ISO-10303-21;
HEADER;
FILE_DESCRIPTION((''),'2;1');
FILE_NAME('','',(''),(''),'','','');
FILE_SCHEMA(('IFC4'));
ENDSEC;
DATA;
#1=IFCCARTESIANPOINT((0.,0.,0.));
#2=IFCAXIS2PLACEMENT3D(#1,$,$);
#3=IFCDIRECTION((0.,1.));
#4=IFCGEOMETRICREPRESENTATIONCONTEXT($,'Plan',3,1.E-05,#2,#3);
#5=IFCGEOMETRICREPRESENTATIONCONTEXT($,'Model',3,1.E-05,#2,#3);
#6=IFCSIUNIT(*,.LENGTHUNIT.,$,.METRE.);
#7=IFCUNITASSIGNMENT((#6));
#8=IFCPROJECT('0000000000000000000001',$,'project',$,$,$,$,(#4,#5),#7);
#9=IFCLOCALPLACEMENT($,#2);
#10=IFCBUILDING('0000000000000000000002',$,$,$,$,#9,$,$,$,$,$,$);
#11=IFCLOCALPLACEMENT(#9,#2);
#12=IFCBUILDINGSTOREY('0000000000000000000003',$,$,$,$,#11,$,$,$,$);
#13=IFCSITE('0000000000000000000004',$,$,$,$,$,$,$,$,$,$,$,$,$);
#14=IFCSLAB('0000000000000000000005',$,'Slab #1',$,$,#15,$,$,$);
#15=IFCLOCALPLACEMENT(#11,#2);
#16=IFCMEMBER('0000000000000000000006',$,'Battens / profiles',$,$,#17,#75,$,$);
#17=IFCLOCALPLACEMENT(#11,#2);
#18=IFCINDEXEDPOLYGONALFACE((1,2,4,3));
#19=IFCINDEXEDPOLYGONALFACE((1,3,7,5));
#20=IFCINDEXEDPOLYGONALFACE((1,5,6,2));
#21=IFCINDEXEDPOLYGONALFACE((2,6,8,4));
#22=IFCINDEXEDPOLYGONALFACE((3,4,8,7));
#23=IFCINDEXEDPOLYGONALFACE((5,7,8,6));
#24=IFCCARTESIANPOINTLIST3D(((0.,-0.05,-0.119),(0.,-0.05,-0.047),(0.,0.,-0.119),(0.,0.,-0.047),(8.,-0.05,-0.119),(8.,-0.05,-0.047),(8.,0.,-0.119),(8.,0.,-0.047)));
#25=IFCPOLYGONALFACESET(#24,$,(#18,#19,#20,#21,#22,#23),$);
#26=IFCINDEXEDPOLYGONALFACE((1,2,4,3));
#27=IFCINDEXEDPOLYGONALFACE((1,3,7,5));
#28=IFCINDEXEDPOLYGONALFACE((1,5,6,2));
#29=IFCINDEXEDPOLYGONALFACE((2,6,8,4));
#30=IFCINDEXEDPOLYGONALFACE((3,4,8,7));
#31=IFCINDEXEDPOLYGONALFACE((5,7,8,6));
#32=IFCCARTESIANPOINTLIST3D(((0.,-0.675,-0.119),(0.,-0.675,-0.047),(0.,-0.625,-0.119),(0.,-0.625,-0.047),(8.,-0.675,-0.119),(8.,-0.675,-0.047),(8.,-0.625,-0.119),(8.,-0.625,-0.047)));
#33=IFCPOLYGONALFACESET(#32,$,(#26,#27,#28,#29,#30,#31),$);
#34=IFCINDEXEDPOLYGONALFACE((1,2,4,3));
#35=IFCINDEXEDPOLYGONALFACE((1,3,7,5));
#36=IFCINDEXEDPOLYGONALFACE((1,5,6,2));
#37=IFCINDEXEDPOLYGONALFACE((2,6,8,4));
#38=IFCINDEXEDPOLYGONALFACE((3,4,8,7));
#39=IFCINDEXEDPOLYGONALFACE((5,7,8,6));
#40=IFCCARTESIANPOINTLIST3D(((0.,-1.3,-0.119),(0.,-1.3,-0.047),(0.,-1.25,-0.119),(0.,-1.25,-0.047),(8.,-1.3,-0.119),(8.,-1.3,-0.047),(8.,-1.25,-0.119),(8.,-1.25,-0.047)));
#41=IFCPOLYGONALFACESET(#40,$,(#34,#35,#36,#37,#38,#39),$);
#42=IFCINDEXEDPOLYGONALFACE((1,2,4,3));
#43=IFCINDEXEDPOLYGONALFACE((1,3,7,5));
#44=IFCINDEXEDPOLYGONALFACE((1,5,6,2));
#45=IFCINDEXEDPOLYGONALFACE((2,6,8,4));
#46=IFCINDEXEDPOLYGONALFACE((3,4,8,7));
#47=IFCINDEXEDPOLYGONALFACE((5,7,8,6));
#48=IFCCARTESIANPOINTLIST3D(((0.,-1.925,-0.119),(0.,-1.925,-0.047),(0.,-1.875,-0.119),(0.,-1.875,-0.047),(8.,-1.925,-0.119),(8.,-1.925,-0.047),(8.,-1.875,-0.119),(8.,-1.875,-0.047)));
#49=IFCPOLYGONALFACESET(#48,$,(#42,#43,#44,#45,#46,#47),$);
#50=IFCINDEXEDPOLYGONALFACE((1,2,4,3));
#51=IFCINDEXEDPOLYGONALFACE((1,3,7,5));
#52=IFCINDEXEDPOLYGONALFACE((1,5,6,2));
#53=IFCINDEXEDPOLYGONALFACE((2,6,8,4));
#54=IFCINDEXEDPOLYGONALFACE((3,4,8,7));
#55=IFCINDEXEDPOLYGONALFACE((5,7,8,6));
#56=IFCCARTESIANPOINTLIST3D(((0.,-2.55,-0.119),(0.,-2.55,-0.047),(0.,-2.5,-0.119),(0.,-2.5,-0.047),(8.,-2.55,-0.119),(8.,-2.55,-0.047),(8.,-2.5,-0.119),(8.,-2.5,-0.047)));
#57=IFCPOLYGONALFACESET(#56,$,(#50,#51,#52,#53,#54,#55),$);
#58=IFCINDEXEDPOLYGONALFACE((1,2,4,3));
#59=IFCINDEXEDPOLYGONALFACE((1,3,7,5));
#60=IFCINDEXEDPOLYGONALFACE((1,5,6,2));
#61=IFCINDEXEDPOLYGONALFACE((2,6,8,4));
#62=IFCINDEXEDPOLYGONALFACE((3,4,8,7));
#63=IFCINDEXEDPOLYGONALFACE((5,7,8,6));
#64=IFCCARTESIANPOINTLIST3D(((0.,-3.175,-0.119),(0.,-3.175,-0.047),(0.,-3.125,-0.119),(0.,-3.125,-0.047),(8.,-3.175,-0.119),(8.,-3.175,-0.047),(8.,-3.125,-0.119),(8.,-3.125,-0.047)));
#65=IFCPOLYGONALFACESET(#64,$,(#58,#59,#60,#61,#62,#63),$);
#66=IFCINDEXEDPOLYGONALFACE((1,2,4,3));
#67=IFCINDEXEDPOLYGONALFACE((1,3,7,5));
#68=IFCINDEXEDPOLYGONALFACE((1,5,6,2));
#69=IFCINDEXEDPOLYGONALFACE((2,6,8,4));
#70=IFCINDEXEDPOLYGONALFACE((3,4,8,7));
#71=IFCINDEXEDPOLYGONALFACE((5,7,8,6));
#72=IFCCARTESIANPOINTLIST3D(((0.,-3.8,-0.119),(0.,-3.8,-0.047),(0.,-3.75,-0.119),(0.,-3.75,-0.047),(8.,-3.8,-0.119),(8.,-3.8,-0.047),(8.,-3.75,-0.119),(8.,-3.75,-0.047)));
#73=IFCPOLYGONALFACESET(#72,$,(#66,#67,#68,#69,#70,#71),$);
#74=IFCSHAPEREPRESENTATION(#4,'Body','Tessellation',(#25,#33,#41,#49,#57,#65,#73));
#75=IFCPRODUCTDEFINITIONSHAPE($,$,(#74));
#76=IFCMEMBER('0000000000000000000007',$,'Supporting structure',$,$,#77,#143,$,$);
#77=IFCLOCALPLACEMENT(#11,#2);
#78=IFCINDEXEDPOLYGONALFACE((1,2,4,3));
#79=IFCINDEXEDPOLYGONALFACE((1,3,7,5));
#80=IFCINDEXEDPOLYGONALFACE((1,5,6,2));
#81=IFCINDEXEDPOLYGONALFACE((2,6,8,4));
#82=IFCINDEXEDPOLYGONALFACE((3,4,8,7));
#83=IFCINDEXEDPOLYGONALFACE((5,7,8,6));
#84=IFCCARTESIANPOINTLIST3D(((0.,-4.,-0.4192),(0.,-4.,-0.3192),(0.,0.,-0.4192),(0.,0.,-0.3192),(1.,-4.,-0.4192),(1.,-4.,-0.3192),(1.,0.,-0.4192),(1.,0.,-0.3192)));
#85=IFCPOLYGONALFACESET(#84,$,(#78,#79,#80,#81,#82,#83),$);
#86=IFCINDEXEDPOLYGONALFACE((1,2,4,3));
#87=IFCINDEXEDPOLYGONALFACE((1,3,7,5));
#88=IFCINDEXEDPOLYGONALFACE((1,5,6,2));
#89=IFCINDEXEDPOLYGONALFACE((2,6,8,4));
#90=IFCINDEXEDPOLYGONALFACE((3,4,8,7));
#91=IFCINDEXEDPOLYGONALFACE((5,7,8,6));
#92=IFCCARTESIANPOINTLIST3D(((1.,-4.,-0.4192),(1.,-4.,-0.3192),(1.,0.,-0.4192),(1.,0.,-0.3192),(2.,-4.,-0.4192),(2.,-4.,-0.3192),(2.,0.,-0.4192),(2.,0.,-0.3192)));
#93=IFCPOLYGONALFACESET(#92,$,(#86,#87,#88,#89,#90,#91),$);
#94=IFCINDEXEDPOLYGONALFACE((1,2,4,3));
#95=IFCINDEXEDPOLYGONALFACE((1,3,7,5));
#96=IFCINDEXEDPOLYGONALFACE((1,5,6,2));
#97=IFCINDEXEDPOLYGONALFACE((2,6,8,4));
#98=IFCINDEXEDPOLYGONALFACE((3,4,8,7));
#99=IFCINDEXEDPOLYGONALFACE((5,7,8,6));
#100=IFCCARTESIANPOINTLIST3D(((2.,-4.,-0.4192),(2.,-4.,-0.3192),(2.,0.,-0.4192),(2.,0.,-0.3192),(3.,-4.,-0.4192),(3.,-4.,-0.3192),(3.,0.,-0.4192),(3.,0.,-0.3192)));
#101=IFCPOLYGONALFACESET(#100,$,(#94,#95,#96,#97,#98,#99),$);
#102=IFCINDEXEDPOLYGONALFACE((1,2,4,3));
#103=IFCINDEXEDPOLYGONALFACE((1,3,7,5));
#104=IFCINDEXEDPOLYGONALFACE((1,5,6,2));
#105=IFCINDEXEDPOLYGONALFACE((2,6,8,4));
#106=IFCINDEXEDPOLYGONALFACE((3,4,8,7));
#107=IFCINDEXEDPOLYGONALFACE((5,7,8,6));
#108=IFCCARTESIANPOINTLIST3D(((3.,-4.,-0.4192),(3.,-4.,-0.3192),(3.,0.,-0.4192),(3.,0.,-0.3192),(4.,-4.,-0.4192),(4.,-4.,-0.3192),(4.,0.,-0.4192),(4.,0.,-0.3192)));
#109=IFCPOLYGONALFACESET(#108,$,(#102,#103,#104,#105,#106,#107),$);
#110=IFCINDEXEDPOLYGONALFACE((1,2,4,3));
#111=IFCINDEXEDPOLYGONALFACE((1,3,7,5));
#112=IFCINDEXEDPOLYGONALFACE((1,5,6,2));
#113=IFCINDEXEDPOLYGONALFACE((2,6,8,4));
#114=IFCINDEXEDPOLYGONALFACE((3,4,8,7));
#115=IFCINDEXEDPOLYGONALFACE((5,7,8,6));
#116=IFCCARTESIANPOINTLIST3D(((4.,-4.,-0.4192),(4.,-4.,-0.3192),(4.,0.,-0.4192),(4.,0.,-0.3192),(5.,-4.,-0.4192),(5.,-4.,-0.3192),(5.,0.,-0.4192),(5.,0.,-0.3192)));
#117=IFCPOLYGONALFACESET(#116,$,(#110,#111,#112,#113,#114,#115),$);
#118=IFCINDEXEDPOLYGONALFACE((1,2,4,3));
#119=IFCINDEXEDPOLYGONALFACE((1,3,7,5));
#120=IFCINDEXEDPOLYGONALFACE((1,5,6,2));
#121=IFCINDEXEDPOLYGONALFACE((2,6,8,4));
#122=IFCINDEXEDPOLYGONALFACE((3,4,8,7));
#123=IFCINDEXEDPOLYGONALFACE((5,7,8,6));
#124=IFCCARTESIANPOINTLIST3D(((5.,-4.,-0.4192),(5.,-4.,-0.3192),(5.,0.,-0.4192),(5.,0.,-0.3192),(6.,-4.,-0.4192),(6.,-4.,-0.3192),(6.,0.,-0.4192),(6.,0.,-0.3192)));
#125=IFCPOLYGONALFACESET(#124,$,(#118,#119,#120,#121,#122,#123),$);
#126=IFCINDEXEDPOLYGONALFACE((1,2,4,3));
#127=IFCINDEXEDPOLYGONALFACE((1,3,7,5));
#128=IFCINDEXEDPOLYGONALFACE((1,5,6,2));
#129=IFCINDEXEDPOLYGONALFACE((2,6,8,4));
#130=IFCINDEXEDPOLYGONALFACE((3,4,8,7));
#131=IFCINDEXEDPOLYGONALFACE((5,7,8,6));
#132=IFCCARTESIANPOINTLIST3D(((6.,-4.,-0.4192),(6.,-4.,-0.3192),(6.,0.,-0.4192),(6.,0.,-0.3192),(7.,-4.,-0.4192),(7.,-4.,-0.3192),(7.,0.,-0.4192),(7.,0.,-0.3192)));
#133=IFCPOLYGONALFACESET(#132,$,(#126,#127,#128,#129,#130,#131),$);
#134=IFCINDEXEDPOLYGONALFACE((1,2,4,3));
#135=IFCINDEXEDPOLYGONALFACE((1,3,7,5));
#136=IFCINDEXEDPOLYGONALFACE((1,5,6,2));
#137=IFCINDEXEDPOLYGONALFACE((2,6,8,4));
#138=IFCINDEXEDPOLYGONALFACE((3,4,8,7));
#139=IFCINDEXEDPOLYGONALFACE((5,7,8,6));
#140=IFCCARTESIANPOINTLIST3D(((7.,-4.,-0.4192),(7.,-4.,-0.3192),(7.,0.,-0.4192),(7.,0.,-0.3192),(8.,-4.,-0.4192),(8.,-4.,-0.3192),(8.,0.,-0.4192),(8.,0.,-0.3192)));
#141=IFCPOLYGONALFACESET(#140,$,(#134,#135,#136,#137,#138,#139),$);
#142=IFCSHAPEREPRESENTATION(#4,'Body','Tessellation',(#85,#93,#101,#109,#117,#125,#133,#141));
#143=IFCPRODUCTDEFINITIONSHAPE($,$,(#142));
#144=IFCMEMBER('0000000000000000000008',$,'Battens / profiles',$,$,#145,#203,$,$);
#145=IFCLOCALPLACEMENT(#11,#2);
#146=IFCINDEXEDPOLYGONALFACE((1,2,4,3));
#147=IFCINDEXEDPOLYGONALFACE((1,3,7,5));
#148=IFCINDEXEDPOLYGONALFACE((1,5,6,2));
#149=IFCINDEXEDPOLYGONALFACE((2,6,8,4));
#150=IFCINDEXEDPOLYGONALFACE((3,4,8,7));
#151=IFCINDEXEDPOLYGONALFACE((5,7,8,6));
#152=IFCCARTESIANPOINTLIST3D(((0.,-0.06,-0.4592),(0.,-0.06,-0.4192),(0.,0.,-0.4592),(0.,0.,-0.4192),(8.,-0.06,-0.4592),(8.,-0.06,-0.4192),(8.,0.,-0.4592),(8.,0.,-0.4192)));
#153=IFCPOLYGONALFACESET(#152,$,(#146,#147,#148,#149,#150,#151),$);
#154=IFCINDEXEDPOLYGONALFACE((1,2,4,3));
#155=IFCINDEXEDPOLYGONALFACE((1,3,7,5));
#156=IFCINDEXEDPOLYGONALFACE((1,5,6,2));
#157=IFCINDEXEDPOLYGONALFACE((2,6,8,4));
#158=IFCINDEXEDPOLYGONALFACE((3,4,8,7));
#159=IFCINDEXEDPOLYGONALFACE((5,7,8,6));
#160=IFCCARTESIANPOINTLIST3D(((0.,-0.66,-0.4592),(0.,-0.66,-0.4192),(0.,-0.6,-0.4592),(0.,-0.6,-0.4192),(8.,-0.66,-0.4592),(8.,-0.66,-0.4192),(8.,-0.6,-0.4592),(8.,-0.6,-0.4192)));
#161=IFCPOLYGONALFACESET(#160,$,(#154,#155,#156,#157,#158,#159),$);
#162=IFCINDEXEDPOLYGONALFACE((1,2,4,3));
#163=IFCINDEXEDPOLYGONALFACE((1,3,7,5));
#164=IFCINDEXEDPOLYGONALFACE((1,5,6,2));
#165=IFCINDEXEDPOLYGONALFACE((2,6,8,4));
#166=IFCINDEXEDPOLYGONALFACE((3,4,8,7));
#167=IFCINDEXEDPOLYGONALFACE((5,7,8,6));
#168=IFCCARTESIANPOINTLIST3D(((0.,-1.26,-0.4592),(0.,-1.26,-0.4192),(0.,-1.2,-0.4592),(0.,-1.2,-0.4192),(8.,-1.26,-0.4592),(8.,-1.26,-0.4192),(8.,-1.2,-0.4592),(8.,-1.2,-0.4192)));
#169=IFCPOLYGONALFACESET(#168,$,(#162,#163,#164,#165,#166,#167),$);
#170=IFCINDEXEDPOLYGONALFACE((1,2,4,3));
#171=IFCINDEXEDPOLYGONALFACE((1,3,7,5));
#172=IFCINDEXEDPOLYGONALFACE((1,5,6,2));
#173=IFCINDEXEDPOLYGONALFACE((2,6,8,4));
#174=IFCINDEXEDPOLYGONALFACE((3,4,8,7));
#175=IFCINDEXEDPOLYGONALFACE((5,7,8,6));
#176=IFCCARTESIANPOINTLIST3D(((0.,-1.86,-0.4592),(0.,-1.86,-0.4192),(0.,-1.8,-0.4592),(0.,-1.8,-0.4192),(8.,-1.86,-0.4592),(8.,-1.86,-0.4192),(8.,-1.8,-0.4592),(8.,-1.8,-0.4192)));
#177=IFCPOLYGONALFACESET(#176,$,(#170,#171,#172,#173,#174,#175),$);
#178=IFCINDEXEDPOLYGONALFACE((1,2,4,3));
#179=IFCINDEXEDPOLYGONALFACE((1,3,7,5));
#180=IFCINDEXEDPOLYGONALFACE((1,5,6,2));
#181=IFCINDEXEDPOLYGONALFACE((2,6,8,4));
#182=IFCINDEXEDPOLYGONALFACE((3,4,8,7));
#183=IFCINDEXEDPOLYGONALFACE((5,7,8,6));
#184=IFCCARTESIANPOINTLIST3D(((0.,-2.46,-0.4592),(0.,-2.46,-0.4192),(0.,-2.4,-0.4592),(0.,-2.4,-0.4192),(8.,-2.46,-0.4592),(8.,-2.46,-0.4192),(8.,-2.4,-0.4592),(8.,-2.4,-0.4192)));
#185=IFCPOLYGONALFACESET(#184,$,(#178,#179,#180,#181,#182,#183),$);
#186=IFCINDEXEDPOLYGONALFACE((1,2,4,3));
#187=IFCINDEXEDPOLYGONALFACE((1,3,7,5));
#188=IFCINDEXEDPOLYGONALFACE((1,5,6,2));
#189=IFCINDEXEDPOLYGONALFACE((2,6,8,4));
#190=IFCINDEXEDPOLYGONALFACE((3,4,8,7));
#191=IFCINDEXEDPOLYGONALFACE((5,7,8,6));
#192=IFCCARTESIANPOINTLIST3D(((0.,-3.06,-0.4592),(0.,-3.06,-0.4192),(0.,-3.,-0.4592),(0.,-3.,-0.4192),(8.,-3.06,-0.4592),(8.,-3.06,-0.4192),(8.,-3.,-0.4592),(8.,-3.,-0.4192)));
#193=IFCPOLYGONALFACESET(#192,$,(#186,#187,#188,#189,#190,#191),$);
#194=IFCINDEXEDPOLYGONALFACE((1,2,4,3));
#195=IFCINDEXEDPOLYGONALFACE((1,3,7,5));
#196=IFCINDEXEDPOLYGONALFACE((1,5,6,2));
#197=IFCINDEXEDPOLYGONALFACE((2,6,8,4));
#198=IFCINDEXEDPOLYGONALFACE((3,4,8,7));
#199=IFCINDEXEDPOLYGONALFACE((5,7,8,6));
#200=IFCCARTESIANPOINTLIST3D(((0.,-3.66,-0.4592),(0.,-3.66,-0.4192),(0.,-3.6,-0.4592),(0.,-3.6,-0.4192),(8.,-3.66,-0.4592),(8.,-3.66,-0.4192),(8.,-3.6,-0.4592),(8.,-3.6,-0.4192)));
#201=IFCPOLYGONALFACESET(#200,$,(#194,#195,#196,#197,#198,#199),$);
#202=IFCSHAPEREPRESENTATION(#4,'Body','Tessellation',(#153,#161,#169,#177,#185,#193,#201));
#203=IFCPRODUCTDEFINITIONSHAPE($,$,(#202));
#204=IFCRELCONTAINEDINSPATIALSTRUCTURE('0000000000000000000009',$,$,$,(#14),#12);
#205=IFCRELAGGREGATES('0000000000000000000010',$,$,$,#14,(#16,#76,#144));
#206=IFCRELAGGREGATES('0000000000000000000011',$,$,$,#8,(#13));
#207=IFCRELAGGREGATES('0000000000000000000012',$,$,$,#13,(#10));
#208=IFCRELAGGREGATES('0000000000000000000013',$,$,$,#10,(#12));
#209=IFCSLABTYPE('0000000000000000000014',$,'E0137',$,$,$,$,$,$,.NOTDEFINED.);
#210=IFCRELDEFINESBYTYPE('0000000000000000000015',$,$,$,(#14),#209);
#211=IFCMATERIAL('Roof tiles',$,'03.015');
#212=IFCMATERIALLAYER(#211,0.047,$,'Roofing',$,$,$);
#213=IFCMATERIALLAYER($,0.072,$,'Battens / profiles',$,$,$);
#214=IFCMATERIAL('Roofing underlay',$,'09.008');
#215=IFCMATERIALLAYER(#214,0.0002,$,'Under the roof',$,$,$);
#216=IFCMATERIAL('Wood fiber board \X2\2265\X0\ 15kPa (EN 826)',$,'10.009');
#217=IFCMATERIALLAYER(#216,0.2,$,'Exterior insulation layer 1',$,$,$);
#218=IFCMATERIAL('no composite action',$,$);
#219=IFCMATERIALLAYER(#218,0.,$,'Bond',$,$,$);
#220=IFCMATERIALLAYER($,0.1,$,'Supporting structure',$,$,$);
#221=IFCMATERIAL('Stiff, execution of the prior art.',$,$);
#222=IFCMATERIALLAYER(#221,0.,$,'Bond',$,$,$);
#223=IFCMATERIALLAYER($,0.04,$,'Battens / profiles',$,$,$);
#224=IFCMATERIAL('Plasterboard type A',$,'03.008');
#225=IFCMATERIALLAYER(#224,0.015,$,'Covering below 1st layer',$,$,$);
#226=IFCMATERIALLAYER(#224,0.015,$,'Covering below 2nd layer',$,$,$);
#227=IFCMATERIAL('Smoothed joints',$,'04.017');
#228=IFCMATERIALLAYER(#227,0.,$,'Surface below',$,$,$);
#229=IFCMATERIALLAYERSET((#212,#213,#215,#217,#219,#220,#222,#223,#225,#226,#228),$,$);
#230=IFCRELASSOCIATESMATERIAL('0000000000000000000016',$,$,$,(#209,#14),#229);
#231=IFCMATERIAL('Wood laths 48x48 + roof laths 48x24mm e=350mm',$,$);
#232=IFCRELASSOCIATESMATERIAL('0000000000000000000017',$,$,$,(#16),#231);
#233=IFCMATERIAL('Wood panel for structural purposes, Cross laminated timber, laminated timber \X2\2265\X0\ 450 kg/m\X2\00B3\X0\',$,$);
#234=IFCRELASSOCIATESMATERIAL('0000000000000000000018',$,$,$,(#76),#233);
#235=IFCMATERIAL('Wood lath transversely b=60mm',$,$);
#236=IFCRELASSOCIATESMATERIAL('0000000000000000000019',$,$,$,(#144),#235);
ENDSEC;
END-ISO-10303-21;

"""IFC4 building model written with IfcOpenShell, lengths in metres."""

from ifc_helpers import new_model, si_unit, direction, frame, frame_2d, origin, place, context, project, spatial, rectangle, extrude, material, layer, layer_set, type_object, element, aggregate, save


model = new_model("IFC4")

# Units and contexts
plan_context = context("Plan", 3, precision=1e-05, world=origin(), true_north=direction((0.0, 1.0)))
model_context = context("Model", 3, precision=1e-05, world=origin(), true_north=direction((0.0, 1.0)))
ifc_project = project(units=[si_unit("LENGTHUNIT", "METRE")], contexts=[plan_context, model_context])

# Site, building, storey
site = spatial("IfcSite", under=ifc_project)
building_placement = place(None, origin())
building = spatial("IfcBuilding", under=site, at=building_placement)
storey_placement = place(building_placement, origin())
storey = spatial("IfcBuildingStorey", under=building, at=storey_placement)

# Slab, members
ifc_material_1 = material(Name="Roof tiles", Category="03.015")
ifc_layer_1 = layer(ifc_material_1, 0.047, Name="Roofing")
ifc_layer_2 = layer(None, 0.072, Name="Battens / profiles")
ifc_material_2 = material(Name="Roofing underlay", Category="09.008")
ifc_layer_3 = layer(ifc_material_2, 0.0002, Name="Under the roof")
ifc_material_3 = material(Name="Wood fiber board ≥ 15kPa (EN 826)", Category="10.009")
ifc_layer_4 = layer(ifc_material_3, 0.2, Name="Exterior insulation layer 1")
ifc_material_4 = material(Name="no composite action")
ifc_layer_5 = layer(ifc_material_4, 0.0, Name="Bond")
ifc_layer_6 = layer(None, 0.1, Name="Supporting structure")
ifc_material_5 = material(Name="Stiff, execution of the prior art.")
ifc_layer_7 = layer(ifc_material_5, 0.0, Name="Bond")
ifc_layer_8 = layer(None, 0.04, Name="Battens / profiles")
ifc_material_6 = material(Name="Plasterboard type A", Category="03.008")
ifc_layer_9 = layer(ifc_material_6, 0.015, Name="Covering below 1st layer")
ifc_layer_10 = layer(ifc_material_6, 0.015, Name="Covering below 2nd layer")
ifc_material_7 = material(Name="Smoothed joints", Category="04.017")
ifc_layer_11 = layer(ifc_material_7, 0.0, Name="Surface below")
ifc_layer_set = layer_set([ifc_layer_1, ifc_layer_2, ifc_layer_3, ifc_layer_4, ifc_layer_5, ifc_layer_6, ifc_layer_7, ifc_layer_8, ifc_layer_9, ifc_layer_10, ifc_layer_11])
slab_type = type_object("IfcSlabType", Name="E0137", PredefinedType="NOTDEFINED", material=ifc_layer_set)
slab_placement = place(None, frame((0.0, 0.0, 0.0), z_axis=(0.0, 0.0, -1.0), x_axis=(1.0, 0.0, 0.0)))
slab = element("IfcSlab", 1, at=slab_placement, inside=storey, type_object=slab_type, material=ifc_layer_set, Name="Slab #1")
ifc_material_8 = material(Name="Wood laths 48x48 + roof laths 48x24mm e=350mm")
member_1_placement = place(slab_placement, origin())
member_1 = element("IfcMember", 2, at=member_1_placement, material=ifc_material_8, Name="Battens / profiles", context=plan_context, shape_type="SweptSolid", body=[
    extrude(rectangle(XDim=0.05, YDim=0.072, at=frame_2d((0.025, 0.036), x_axis=(1.0, 0.0))), frame((0.0, 0.0, 0.047), z_axis=(1.0, 0.0, 0.0), x_axis=(0.0, 1.0, 0.0)), (0.0, 0.0, 1.0), 8.0),
    extrude(rectangle(XDim=0.05, YDim=0.072, at=frame_2d((0.025, 0.036), x_axis=(1.0, 0.0))), frame((0.0, 0.625, 0.047), z_axis=(1.0, 0.0, 0.0), x_axis=(0.0, 1.0, 0.0)), (0.0, 0.0, 1.0), 8.0),
    extrude(rectangle(XDim=0.05, YDim=0.072, at=frame_2d((0.025, 0.036), x_axis=(1.0, 0.0))), frame((0.0, 1.25, 0.047), z_axis=(1.0, 0.0, 0.0), x_axis=(0.0, 1.0, 0.0)), (0.0, 0.0, 1.0), 8.0),
    extrude(rectangle(XDim=0.05, YDim=0.072, at=frame_2d((0.025, 0.036), x_axis=(1.0, 0.0))), frame((0.0, 1.875, 0.047), z_axis=(1.0, 0.0, 0.0), x_axis=(0.0, 1.0, 0.0)), (0.0, 0.0, 1.0), 8.0),
    extrude(rectangle(XDim=0.05, YDim=0.072, at=frame_2d((0.025, 0.036), x_axis=(1.0, 0.0))), frame((0.0, 2.5, 0.047), z_axis=(1.0, 0.0, 0.0), x_axis=(0.0, 1.0, 0.0)), (0.0, 0.0, 1.0), 8.0),
    extrude(rectangle(XDim=0.05, YDim=0.072, at=frame_2d((0.025, 0.036), x_axis=(1.0, 0.0))), frame((0.0, 3.125, 0.047), z_axis=(1.0, 0.0, 0.0), x_axis=(0.0, 1.0, 0.0)), (0.0, 0.0, 1.0), 8.0),
    extrude(rectangle(XDim=0.05, YDim=0.072, at=frame_2d((0.025, 0.036), x_axis=(1.0, 0.0))), frame((0.0, 3.75, 0.047), z_axis=(1.0, 0.0, 0.0), x_axis=(0.0, 1.0, 0.0)), (0.0, 0.0, 1.0), 8.0),
])
ifc_material_9 = material(Name="Wood panel for structural purposes, Cross laminated timber, laminated timber ≥ 450 kg/m³")
member_2_placement = place(slab_placement, origin())
member_2 = element("IfcMember", 3, at=member_2_placement, material=ifc_material_9, Name="Supporting structure", context=plan_context, shape_type="SweptSolid", body=[
    extrude(rectangle(XDim=1.0, YDim=0.1, at=frame_2d((0.5, 0.05), x_axis=(1.0, 0.0))), frame((0.0, 4.0, 0.3192), z_axis=(0.0, -1.0, 0.0), x_axis=(1.0, 0.0, 0.0)), (0.0, 0.0, 1.0), 4.0),
    extrude(rectangle(XDim=1.0, YDim=0.1, at=frame_2d((0.5, 0.05), x_axis=(1.0, 0.0))), frame((1.0, 4.0, 0.3192), z_axis=(0.0, -1.0, 0.0), x_axis=(1.0, 0.0, 0.0)), (0.0, 0.0, 1.0), 4.0),
    extrude(rectangle(XDim=1.0, YDim=0.1, at=frame_2d((0.5, 0.05), x_axis=(1.0, 0.0))), frame((2.0, 4.0, 0.3192), z_axis=(0.0, -1.0, 0.0), x_axis=(1.0, 0.0, 0.0)), (0.0, 0.0, 1.0), 4.0),
    extrude(rectangle(XDim=1.0, YDim=0.1, at=frame_2d((0.5, 0.05), x_axis=(1.0, 0.0))), frame((3.0, 4.0, 0.3192), z_axis=(0.0, -1.0, 0.0), x_axis=(1.0, 0.0, 0.0)), (0.0, 0.0, 1.0), 4.0),
    extrude(rectangle(XDim=1.0, YDim=0.1, at=frame_2d((0.5, 0.05), x_axis=(1.0, 0.0))), frame((4.0, 4.0, 0.3192), z_axis=(0.0, -1.0, 0.0), x_axis=(1.0, 0.0, 0.0)), (0.0, 0.0, 1.0), 4.0),
    extrude(rectangle(XDim=1.0, YDim=0.1, at=frame_2d((0.5, 0.05), x_axis=(1.0, 0.0))), frame((5.0, 4.0, 0.3192), z_axis=(0.0, -1.0, 0.0), x_axis=(1.0, 0.0, 0.0)), (0.0, 0.0, 1.0), 4.0),
    extrude(rectangle(XDim=1.0, YDim=0.1, at=frame_2d((0.5, 0.05), x_axis=(1.0, 0.0))), frame((6.0, 4.0, 0.3192), z_axis=(0.0, -1.0, 0.0), x_axis=(1.0, 0.0, 0.0)), (0.0, 0.0, 1.0), 4.0),
    extrude(rectangle(XDim=1.0, YDim=0.1, at=frame_2d((0.5, 0.05), x_axis=(1.0, 0.0))), frame((7.0, 4.0, 0.3192), z_axis=(0.0, -1.0, 0.0), x_axis=(1.0, 0.0, 0.0)), (0.0, 0.0, 1.0), 4.0),
])
ifc_material_10 = material(Name="Wood lath transversely b=60mm")
member_3_placement = place(slab_placement, origin())
member_3 = element("IfcMember", 4, at=member_3_placement, material=ifc_material_10, Name="Battens / profiles", context=plan_context, shape_type="SweptSolid", body=[
    extrude(rectangle(XDim=0.06, YDim=0.04, at=frame_2d((0.03, 0.02), x_axis=(1.0, 0.0))), frame((0.0, 0.0, 0.4192), z_axis=(1.0, 0.0, 0.0), x_axis=(0.0, 1.0, 0.0)), (0.0, 0.0, 1.0), 8.0),
    extrude(rectangle(XDim=0.06, YDim=0.04, at=frame_2d((0.03, 0.02), x_axis=(1.0, 0.0))), frame((0.0, 0.6, 0.4192), z_axis=(1.0, 0.0, 0.0), x_axis=(0.0, 1.0, 0.0)), (0.0, 0.0, 1.0), 8.0),
    extrude(rectangle(XDim=0.06, YDim=0.04, at=frame_2d((0.03, 0.02), x_axis=(1.0, 0.0))), frame((0.0, 1.2, 0.4192), z_axis=(1.0, 0.0, 0.0), x_axis=(0.0, 1.0, 0.0)), (0.0, 0.0, 1.0), 8.0),
    extrude(rectangle(XDim=0.06, YDim=0.04, at=frame_2d((0.03, 0.02), x_axis=(1.0, 0.0))), frame((0.0, 1.8, 0.4192), z_axis=(1.0, 0.0, 0.0), x_axis=(0.0, 1.0, 0.0)), (0.0, 0.0, 1.0), 8.0),
    extrude(rectangle(XDim=0.06, YDim=0.04, at=frame_2d((0.03, 0.02), x_axis=(1.0, 0.0))), frame((0.0, 2.4, 0.4192), z_axis=(1.0, 0.0, 0.0), x_axis=(0.0, 1.0, 0.0)), (0.0, 0.0, 1.0), 8.0),
    extrude(rectangle(XDim=0.06, YDim=0.04, at=frame_2d((0.03, 0.02), x_axis=(1.0, 0.0))), frame((0.0, 3.0, 0.4192), z_axis=(1.0, 0.0, 0.0), x_axis=(0.0, 1.0, 0.0)), (0.0, 0.0, 1.0), 8.0),
    extrude(rectangle(XDim=0.06, YDim=0.04, at=frame_2d((0.03, 0.02), x_axis=(1.0, 0.0))), frame((0.0, 3.6, 0.4192), z_axis=(1.0, 0.0, 0.0), x_axis=(0.0, 1.0, 0.0)), (0.0, 0.0, 1.0), 8.0),
])
aggregate(slab, [member_1, member_2, member_3])

save(model, "model.ifc")
